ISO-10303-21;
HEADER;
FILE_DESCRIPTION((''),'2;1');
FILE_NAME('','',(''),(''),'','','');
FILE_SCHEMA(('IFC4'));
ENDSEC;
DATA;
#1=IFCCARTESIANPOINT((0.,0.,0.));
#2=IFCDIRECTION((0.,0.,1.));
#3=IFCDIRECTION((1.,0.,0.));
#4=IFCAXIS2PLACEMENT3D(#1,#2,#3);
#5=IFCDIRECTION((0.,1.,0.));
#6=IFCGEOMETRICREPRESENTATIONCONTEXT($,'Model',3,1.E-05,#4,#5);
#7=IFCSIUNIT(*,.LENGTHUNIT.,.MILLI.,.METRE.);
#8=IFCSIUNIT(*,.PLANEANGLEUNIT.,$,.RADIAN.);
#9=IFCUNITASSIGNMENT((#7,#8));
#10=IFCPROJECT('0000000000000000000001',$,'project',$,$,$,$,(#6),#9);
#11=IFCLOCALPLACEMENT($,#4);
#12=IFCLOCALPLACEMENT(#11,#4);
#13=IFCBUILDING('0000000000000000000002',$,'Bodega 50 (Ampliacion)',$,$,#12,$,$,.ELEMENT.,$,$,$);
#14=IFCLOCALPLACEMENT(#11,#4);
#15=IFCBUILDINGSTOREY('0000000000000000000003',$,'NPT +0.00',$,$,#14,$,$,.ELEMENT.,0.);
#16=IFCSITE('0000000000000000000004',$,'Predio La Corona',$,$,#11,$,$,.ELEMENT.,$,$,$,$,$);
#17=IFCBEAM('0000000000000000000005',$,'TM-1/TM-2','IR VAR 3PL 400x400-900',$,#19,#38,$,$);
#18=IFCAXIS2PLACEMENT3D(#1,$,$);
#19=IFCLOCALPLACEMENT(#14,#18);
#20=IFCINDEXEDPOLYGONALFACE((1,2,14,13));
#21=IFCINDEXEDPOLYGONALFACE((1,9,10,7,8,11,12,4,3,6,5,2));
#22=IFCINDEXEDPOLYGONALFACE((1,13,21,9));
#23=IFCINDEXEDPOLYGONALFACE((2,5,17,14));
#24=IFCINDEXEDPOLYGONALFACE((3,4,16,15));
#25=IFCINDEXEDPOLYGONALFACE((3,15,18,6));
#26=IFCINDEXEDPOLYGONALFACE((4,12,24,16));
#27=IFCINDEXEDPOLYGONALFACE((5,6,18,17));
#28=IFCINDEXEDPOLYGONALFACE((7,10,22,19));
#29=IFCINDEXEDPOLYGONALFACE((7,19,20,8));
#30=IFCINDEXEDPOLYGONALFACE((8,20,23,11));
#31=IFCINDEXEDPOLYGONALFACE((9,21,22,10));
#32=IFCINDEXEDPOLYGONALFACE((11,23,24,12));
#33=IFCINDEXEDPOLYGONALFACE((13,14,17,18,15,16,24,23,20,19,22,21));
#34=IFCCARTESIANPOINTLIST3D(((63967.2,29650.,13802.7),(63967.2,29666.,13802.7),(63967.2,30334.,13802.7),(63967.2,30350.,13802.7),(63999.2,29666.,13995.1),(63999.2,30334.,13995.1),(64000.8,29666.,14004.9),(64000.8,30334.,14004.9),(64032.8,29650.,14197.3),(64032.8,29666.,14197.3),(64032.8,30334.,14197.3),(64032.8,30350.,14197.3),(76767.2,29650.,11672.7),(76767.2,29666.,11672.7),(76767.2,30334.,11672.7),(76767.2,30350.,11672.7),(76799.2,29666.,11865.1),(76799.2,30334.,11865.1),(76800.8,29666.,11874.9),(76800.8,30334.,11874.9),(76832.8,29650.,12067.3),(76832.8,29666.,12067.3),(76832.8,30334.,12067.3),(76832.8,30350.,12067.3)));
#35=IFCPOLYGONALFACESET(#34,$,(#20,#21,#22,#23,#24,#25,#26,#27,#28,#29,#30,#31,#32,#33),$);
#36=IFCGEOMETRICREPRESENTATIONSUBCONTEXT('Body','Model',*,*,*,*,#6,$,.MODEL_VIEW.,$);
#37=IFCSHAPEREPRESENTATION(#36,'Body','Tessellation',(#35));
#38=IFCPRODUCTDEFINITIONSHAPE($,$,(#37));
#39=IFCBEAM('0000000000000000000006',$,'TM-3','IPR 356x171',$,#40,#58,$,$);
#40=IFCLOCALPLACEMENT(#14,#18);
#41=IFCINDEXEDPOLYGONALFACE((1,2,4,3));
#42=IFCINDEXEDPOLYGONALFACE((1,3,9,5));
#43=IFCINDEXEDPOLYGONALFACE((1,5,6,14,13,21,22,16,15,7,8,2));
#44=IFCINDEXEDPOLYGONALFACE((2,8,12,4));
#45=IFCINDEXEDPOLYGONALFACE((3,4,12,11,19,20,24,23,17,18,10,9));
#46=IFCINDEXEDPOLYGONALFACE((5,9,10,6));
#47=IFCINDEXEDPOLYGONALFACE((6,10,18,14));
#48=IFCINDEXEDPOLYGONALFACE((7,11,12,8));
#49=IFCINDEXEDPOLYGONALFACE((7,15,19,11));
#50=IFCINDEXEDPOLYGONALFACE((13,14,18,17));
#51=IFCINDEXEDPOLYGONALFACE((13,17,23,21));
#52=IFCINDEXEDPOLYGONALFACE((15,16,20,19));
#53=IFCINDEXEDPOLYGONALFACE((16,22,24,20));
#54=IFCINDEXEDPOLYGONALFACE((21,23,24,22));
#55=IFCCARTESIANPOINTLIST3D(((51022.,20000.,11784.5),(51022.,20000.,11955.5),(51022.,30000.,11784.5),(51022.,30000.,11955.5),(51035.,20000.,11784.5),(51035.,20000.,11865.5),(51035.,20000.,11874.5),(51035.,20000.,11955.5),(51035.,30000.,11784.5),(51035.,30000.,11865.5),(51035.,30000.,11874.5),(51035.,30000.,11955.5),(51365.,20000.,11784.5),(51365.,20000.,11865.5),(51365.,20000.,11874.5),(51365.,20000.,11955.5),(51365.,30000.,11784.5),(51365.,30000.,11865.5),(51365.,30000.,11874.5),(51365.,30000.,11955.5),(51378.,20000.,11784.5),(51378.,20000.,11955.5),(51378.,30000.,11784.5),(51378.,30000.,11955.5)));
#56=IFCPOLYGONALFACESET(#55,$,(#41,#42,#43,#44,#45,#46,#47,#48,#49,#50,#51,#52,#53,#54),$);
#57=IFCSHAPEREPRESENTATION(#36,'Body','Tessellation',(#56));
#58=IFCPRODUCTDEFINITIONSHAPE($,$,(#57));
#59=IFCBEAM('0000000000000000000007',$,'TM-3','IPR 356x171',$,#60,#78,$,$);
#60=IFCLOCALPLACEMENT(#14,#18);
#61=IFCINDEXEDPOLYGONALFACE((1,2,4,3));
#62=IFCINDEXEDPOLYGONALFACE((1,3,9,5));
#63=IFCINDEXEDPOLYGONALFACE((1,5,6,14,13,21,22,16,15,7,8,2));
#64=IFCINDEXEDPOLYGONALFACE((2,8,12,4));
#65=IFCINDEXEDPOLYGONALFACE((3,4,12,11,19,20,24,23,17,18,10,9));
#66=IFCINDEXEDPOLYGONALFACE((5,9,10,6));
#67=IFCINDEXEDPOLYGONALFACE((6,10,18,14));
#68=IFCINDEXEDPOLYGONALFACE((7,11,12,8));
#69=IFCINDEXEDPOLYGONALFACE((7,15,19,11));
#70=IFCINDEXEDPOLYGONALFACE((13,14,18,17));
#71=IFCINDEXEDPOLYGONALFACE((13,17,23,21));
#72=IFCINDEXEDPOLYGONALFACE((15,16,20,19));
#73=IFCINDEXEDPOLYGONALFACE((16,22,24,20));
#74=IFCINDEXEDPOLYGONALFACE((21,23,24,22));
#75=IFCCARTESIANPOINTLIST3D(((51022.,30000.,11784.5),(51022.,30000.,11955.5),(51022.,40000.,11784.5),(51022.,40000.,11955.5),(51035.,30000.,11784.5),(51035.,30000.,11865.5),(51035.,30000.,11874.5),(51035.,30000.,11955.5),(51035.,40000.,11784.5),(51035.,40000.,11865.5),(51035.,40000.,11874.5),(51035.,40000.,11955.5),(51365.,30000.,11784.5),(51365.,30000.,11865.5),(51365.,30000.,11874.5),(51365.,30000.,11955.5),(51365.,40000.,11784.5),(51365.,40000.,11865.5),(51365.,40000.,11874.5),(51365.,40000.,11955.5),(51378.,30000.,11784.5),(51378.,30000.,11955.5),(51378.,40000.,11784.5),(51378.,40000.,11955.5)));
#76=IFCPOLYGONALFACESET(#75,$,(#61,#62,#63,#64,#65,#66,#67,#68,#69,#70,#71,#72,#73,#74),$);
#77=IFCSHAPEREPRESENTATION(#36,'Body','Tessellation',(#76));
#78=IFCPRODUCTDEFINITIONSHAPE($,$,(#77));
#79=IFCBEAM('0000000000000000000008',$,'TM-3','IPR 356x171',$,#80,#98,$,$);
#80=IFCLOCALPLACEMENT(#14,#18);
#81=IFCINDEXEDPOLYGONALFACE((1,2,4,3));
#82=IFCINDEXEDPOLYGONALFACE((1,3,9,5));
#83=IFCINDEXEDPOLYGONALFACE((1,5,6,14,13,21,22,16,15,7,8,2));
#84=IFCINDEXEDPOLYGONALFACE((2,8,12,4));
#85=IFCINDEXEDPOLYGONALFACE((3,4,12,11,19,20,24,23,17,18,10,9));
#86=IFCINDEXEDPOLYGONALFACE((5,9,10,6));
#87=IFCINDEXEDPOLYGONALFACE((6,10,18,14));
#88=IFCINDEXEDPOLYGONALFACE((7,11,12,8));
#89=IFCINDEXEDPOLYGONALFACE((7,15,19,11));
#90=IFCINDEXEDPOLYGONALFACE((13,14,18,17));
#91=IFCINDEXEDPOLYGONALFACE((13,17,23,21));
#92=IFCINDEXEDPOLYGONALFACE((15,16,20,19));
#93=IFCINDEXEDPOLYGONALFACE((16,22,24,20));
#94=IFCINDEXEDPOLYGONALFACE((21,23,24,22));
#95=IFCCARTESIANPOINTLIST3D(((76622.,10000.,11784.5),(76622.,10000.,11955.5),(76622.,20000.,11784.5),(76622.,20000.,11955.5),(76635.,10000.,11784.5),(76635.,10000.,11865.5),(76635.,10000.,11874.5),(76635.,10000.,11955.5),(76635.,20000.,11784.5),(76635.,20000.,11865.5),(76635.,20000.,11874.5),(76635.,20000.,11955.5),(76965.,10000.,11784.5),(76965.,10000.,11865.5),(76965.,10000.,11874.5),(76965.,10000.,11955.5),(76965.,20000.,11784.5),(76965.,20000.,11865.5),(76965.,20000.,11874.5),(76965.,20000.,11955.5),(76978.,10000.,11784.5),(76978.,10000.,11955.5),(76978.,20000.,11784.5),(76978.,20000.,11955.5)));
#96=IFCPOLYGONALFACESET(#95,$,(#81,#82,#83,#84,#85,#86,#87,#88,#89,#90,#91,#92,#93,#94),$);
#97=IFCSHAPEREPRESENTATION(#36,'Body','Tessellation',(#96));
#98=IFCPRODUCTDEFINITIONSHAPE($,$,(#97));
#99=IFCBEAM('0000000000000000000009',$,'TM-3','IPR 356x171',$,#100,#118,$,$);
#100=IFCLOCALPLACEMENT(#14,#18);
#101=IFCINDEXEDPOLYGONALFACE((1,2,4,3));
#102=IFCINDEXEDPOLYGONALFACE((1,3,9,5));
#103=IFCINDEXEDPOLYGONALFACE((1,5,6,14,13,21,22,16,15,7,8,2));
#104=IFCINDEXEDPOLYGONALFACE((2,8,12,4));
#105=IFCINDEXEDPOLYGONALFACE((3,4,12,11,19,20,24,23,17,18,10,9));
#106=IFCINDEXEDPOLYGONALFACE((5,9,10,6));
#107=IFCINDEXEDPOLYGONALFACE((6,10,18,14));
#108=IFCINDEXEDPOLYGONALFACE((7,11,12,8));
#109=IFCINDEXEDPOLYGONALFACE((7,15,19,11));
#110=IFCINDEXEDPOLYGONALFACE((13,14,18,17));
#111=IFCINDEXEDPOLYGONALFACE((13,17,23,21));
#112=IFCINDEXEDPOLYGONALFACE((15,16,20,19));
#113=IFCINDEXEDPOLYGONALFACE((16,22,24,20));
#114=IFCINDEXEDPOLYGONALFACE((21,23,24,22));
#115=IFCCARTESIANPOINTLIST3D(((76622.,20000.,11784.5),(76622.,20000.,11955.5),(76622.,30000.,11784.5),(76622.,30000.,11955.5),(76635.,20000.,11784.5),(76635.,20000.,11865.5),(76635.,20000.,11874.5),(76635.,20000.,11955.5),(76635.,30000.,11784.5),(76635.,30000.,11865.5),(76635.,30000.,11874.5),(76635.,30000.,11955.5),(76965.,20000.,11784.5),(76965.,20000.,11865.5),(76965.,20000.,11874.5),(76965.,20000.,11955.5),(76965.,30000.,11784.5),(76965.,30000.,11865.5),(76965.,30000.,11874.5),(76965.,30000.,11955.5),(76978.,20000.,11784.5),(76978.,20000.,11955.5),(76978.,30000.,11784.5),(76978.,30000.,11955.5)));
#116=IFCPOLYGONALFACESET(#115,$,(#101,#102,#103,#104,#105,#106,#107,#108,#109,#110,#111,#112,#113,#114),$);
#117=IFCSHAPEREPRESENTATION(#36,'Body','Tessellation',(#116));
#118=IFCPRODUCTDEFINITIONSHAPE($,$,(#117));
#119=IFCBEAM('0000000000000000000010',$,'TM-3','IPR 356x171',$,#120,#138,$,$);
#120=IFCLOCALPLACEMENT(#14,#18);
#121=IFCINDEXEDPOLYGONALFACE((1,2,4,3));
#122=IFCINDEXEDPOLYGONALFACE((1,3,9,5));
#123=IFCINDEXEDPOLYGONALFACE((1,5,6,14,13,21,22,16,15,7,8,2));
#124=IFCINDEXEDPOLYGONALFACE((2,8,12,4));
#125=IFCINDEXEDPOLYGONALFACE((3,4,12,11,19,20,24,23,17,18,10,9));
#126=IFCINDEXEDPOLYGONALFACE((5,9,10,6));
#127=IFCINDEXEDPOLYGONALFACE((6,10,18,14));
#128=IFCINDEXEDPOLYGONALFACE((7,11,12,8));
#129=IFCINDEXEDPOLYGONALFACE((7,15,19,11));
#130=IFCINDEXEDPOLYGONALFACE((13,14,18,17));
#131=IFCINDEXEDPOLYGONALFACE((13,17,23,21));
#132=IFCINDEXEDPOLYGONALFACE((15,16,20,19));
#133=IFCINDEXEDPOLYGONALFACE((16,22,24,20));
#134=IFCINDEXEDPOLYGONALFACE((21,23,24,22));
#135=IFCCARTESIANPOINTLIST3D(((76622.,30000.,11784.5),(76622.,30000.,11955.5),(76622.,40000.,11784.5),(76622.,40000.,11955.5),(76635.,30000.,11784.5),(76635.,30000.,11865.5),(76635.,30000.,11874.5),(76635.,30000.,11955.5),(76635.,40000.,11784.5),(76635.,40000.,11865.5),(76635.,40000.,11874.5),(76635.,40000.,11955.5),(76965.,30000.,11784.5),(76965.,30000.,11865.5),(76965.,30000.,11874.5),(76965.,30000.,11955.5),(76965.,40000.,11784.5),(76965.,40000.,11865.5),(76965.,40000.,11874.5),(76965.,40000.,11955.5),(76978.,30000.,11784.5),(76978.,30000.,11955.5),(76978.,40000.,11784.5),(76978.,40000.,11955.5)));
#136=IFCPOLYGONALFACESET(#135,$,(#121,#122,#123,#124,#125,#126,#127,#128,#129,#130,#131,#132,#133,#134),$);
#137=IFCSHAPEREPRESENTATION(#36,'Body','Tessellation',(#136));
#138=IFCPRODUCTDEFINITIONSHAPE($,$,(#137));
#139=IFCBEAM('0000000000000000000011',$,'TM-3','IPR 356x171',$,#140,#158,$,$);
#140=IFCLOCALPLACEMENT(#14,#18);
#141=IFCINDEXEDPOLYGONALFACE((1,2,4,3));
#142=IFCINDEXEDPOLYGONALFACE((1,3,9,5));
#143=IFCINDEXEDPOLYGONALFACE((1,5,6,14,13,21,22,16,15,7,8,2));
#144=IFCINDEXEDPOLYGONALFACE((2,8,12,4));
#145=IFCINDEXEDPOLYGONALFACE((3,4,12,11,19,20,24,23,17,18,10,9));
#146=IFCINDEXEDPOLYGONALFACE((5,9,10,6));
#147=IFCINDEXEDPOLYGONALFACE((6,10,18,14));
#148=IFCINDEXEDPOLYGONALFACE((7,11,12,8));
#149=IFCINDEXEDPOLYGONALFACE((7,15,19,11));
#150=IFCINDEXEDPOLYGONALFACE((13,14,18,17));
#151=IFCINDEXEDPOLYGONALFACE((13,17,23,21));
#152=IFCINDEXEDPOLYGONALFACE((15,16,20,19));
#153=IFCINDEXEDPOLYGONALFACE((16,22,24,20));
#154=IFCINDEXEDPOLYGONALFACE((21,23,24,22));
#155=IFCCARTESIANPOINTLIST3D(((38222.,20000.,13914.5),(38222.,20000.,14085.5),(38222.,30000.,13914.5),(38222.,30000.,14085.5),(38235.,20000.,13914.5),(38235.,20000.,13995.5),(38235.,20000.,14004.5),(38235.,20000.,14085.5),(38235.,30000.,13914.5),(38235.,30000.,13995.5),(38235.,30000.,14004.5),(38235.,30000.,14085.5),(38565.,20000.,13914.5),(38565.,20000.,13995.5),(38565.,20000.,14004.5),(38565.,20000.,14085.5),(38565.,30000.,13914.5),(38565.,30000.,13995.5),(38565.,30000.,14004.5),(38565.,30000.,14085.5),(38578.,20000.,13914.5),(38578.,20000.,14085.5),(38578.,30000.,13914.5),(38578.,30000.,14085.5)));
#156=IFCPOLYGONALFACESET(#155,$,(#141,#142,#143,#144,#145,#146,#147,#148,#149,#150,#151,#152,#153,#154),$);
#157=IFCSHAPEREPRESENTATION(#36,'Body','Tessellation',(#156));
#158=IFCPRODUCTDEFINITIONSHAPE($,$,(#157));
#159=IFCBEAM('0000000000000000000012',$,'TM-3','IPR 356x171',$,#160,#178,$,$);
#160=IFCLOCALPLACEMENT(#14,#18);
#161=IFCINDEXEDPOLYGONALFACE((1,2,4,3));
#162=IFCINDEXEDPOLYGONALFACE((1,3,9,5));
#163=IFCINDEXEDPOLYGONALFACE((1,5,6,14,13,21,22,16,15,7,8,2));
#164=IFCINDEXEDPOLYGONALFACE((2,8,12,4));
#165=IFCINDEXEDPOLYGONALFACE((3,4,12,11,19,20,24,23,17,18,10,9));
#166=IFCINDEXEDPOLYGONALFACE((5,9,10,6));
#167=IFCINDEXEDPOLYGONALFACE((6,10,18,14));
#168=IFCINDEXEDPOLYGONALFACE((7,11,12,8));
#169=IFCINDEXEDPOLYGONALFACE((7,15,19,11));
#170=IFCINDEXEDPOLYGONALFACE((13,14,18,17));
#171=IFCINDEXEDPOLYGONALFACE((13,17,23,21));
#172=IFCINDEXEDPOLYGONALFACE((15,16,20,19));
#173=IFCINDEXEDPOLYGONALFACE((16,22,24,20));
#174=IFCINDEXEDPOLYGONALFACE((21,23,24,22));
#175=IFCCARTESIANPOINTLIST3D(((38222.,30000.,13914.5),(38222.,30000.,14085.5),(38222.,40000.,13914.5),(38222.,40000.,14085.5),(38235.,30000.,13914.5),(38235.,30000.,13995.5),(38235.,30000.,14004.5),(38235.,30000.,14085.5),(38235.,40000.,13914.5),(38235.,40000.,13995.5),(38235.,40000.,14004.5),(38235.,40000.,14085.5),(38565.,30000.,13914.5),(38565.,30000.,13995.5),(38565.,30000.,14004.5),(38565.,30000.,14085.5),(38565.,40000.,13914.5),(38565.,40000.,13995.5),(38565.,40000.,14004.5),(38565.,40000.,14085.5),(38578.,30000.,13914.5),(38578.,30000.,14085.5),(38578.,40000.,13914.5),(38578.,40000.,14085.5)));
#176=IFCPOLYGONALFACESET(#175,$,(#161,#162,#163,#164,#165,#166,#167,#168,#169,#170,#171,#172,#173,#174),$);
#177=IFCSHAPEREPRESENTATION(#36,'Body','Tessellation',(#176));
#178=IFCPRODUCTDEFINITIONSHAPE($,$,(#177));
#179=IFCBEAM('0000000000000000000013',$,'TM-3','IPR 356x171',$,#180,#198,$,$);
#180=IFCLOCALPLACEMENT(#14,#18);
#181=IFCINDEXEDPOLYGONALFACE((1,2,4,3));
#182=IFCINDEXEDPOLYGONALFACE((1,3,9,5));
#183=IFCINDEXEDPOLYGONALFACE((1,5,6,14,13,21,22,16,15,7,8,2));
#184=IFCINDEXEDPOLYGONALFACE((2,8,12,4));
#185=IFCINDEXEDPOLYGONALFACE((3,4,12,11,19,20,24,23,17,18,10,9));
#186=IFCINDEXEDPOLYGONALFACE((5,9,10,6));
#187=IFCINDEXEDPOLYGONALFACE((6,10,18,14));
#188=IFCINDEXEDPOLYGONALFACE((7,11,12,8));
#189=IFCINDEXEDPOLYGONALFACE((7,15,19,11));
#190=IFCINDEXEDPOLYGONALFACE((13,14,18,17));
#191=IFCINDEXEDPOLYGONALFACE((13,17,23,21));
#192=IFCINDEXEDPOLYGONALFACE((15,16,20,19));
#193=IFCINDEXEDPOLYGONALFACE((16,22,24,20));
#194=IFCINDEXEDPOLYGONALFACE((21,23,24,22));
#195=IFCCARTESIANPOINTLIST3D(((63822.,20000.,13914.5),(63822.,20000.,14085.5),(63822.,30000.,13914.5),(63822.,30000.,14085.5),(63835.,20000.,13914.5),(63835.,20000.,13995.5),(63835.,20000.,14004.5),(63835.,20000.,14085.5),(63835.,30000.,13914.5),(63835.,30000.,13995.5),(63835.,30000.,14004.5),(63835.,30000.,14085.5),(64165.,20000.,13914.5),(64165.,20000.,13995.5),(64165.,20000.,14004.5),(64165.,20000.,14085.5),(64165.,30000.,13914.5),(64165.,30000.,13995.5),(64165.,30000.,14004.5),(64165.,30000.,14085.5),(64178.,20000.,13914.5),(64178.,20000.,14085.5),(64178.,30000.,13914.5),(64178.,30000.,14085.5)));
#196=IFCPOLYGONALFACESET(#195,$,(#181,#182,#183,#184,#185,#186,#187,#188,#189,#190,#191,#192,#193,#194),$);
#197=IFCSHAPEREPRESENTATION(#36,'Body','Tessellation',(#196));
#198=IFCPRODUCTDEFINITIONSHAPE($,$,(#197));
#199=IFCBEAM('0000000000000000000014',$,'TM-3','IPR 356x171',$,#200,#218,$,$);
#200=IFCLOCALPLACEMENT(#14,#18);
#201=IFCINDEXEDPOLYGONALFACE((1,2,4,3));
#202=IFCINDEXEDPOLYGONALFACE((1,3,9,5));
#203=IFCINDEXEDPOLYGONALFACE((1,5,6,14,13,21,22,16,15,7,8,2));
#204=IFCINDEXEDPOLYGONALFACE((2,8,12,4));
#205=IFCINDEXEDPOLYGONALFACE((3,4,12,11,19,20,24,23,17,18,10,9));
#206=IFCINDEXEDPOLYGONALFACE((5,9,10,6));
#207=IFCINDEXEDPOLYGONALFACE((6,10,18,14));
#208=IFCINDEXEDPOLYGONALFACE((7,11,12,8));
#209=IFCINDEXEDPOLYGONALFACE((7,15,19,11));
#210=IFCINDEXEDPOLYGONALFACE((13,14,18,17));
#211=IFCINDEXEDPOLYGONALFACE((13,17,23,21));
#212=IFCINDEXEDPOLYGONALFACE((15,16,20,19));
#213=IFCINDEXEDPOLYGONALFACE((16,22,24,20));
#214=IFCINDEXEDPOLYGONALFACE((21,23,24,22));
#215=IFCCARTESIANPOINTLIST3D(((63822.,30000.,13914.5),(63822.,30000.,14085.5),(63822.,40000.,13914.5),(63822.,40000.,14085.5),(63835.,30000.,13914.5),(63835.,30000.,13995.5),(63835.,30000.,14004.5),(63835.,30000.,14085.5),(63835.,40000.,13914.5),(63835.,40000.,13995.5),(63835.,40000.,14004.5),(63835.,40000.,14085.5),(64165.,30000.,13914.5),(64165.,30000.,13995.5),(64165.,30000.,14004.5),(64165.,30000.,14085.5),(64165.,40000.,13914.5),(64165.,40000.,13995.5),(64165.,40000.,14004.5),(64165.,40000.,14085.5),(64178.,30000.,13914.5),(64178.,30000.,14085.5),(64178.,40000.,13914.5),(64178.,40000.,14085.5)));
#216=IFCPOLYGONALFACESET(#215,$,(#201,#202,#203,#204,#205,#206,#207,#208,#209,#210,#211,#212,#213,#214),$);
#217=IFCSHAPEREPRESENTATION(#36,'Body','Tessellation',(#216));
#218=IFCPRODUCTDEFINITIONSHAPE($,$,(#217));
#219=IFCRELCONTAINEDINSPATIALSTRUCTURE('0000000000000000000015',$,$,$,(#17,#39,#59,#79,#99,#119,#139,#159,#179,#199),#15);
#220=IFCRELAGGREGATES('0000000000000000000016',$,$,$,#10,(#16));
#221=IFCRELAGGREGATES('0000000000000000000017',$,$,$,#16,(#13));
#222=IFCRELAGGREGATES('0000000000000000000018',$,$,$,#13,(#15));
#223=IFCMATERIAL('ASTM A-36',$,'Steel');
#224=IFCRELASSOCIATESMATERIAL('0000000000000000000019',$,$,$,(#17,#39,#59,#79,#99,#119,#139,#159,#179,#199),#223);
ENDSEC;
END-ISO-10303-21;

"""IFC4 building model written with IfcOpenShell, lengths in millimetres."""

from ifc_helpers import new_model, si_unit, direction, frame, origin_with_axes, origin_2d, place, context, subcontext, project, spatial, i_section, extrude, material, element, save


model = new_model("IFC4")

# Units and contexts
model_context = context("Model", 3, precision=1e-05, world=origin_with_axes(), true_north=direction((0.0, 1.0, 0.0)))
body_context = subcontext(model_context, "Body", "Model", "MODEL_VIEW")
ifc_project = project(units=[si_unit("LENGTHUNIT", "METRE", prefix="MILLI"), si_unit("PLANEANGLEUNIT", "RADIAN")], contexts=[model_context])

# Site, building, storey
site_placement = place(None, origin_with_axes())
site = spatial("IfcSite", under=ifc_project, at=site_placement, Name="Predio La Corona", CompositionType="ELEMENT")
building_placement = place(site_placement, origin_with_axes())
building = spatial("IfcBuilding", under=site, at=building_placement, Name="Bodega 50 (Ampliacion)", CompositionType="ELEMENT")
storey_placement = place(site_placement, origin_with_axes())
storey = spatial("IfcBuildingStorey", under=building, at=storey_placement, Name="NPT +0.00", CompositionType="ELEMENT", Elevation=0.0)

# Shared definitions
ifc_material = material(Name="ASTM A-36", Category="Steel")

# Beams
for number, where, z_axis, x_axis, name in (
    (1, (64000.0, 30000.0, 14000.0), (0.986436, 0.0, -0.164149), (-0.164149, 0.0, -0.986436), "TM-1/TM-2"),
):
    element("IfcBeam", number, at=place(storey_placement, frame(where, z_axis=z_axis, x_axis=x_axis)), inside=storey, material=ifc_material, Name=name, Description="IR VAR 3PL 400x400-900", context=body_context, shape_type="SweptSolid", body=[
        extrude(i_section(OverallWidth=400.0, OverallDepth=700.0, WebThickness=10.0, FlangeThickness=16.0, at=origin_2d()), origin_with_axes(), (0.0, 0.0, 1.0), 12976.0),
    ])
for number, where, z_axis, x_axis, name in (
    (2, (51200.0, 20000.0, 11870.0), (0.0, 1.0, 0.0), (0.0, 0.0, 1.0), "TM-3"),
    (3, (51200.0, 30000.0, 11870.0), (0.0, 1.0, 0.0), (0.0, 0.0, 1.0), "TM-3"),
    (4, (76800.0, 10000.0, 11870.0), (0.0, 1.0, 0.0), (0.0, 0.0, 1.0), "TM-3"),
    (5, (76800.0, 20000.0, 11870.0), (0.0, 1.0, 0.0), (0.0, 0.0, 1.0), "TM-3"),
    (6, (76800.0, 30000.0, 11870.0), (0.0, 1.0, 0.0), (0.0, 0.0, 1.0), "TM-3"),
    (7, (38400.0, 20000.0, 14000.0), (0.0, 1.0, 0.0), (0.0, 0.0, 1.0), "TM-3"),
    (8, (38400.0, 30000.0, 14000.0), (0.0, 1.0, 0.0), (0.0, 0.0, 1.0), "TM-3"),
    (9, (64000.0, 20000.0, 14000.0), (0.0, 1.0, 0.0), (0.0, 0.0, 1.0), "TM-3"),
    (10, (64000.0, 30000.0, 14000.0), (0.0, 1.0, 0.0), (0.0, 0.0, 1.0), "TM-3"),
):
    element("IfcBeam", number, at=place(storey_placement, frame(where, z_axis=z_axis, x_axis=x_axis)), inside=storey, material=ifc_material, Name=name, Description="IPR 356x171", context=body_context, shape_type="SweptSolid", body=[
        extrude(i_section(OverallWidth=171.0, OverallDepth=356.0, WebThickness=9.0, FlangeThickness=13.0, at=origin_2d()), origin_with_axes(), (0.0, 0.0, 1.0), 10000.0),
    ])

save(model, "model.ifc")
